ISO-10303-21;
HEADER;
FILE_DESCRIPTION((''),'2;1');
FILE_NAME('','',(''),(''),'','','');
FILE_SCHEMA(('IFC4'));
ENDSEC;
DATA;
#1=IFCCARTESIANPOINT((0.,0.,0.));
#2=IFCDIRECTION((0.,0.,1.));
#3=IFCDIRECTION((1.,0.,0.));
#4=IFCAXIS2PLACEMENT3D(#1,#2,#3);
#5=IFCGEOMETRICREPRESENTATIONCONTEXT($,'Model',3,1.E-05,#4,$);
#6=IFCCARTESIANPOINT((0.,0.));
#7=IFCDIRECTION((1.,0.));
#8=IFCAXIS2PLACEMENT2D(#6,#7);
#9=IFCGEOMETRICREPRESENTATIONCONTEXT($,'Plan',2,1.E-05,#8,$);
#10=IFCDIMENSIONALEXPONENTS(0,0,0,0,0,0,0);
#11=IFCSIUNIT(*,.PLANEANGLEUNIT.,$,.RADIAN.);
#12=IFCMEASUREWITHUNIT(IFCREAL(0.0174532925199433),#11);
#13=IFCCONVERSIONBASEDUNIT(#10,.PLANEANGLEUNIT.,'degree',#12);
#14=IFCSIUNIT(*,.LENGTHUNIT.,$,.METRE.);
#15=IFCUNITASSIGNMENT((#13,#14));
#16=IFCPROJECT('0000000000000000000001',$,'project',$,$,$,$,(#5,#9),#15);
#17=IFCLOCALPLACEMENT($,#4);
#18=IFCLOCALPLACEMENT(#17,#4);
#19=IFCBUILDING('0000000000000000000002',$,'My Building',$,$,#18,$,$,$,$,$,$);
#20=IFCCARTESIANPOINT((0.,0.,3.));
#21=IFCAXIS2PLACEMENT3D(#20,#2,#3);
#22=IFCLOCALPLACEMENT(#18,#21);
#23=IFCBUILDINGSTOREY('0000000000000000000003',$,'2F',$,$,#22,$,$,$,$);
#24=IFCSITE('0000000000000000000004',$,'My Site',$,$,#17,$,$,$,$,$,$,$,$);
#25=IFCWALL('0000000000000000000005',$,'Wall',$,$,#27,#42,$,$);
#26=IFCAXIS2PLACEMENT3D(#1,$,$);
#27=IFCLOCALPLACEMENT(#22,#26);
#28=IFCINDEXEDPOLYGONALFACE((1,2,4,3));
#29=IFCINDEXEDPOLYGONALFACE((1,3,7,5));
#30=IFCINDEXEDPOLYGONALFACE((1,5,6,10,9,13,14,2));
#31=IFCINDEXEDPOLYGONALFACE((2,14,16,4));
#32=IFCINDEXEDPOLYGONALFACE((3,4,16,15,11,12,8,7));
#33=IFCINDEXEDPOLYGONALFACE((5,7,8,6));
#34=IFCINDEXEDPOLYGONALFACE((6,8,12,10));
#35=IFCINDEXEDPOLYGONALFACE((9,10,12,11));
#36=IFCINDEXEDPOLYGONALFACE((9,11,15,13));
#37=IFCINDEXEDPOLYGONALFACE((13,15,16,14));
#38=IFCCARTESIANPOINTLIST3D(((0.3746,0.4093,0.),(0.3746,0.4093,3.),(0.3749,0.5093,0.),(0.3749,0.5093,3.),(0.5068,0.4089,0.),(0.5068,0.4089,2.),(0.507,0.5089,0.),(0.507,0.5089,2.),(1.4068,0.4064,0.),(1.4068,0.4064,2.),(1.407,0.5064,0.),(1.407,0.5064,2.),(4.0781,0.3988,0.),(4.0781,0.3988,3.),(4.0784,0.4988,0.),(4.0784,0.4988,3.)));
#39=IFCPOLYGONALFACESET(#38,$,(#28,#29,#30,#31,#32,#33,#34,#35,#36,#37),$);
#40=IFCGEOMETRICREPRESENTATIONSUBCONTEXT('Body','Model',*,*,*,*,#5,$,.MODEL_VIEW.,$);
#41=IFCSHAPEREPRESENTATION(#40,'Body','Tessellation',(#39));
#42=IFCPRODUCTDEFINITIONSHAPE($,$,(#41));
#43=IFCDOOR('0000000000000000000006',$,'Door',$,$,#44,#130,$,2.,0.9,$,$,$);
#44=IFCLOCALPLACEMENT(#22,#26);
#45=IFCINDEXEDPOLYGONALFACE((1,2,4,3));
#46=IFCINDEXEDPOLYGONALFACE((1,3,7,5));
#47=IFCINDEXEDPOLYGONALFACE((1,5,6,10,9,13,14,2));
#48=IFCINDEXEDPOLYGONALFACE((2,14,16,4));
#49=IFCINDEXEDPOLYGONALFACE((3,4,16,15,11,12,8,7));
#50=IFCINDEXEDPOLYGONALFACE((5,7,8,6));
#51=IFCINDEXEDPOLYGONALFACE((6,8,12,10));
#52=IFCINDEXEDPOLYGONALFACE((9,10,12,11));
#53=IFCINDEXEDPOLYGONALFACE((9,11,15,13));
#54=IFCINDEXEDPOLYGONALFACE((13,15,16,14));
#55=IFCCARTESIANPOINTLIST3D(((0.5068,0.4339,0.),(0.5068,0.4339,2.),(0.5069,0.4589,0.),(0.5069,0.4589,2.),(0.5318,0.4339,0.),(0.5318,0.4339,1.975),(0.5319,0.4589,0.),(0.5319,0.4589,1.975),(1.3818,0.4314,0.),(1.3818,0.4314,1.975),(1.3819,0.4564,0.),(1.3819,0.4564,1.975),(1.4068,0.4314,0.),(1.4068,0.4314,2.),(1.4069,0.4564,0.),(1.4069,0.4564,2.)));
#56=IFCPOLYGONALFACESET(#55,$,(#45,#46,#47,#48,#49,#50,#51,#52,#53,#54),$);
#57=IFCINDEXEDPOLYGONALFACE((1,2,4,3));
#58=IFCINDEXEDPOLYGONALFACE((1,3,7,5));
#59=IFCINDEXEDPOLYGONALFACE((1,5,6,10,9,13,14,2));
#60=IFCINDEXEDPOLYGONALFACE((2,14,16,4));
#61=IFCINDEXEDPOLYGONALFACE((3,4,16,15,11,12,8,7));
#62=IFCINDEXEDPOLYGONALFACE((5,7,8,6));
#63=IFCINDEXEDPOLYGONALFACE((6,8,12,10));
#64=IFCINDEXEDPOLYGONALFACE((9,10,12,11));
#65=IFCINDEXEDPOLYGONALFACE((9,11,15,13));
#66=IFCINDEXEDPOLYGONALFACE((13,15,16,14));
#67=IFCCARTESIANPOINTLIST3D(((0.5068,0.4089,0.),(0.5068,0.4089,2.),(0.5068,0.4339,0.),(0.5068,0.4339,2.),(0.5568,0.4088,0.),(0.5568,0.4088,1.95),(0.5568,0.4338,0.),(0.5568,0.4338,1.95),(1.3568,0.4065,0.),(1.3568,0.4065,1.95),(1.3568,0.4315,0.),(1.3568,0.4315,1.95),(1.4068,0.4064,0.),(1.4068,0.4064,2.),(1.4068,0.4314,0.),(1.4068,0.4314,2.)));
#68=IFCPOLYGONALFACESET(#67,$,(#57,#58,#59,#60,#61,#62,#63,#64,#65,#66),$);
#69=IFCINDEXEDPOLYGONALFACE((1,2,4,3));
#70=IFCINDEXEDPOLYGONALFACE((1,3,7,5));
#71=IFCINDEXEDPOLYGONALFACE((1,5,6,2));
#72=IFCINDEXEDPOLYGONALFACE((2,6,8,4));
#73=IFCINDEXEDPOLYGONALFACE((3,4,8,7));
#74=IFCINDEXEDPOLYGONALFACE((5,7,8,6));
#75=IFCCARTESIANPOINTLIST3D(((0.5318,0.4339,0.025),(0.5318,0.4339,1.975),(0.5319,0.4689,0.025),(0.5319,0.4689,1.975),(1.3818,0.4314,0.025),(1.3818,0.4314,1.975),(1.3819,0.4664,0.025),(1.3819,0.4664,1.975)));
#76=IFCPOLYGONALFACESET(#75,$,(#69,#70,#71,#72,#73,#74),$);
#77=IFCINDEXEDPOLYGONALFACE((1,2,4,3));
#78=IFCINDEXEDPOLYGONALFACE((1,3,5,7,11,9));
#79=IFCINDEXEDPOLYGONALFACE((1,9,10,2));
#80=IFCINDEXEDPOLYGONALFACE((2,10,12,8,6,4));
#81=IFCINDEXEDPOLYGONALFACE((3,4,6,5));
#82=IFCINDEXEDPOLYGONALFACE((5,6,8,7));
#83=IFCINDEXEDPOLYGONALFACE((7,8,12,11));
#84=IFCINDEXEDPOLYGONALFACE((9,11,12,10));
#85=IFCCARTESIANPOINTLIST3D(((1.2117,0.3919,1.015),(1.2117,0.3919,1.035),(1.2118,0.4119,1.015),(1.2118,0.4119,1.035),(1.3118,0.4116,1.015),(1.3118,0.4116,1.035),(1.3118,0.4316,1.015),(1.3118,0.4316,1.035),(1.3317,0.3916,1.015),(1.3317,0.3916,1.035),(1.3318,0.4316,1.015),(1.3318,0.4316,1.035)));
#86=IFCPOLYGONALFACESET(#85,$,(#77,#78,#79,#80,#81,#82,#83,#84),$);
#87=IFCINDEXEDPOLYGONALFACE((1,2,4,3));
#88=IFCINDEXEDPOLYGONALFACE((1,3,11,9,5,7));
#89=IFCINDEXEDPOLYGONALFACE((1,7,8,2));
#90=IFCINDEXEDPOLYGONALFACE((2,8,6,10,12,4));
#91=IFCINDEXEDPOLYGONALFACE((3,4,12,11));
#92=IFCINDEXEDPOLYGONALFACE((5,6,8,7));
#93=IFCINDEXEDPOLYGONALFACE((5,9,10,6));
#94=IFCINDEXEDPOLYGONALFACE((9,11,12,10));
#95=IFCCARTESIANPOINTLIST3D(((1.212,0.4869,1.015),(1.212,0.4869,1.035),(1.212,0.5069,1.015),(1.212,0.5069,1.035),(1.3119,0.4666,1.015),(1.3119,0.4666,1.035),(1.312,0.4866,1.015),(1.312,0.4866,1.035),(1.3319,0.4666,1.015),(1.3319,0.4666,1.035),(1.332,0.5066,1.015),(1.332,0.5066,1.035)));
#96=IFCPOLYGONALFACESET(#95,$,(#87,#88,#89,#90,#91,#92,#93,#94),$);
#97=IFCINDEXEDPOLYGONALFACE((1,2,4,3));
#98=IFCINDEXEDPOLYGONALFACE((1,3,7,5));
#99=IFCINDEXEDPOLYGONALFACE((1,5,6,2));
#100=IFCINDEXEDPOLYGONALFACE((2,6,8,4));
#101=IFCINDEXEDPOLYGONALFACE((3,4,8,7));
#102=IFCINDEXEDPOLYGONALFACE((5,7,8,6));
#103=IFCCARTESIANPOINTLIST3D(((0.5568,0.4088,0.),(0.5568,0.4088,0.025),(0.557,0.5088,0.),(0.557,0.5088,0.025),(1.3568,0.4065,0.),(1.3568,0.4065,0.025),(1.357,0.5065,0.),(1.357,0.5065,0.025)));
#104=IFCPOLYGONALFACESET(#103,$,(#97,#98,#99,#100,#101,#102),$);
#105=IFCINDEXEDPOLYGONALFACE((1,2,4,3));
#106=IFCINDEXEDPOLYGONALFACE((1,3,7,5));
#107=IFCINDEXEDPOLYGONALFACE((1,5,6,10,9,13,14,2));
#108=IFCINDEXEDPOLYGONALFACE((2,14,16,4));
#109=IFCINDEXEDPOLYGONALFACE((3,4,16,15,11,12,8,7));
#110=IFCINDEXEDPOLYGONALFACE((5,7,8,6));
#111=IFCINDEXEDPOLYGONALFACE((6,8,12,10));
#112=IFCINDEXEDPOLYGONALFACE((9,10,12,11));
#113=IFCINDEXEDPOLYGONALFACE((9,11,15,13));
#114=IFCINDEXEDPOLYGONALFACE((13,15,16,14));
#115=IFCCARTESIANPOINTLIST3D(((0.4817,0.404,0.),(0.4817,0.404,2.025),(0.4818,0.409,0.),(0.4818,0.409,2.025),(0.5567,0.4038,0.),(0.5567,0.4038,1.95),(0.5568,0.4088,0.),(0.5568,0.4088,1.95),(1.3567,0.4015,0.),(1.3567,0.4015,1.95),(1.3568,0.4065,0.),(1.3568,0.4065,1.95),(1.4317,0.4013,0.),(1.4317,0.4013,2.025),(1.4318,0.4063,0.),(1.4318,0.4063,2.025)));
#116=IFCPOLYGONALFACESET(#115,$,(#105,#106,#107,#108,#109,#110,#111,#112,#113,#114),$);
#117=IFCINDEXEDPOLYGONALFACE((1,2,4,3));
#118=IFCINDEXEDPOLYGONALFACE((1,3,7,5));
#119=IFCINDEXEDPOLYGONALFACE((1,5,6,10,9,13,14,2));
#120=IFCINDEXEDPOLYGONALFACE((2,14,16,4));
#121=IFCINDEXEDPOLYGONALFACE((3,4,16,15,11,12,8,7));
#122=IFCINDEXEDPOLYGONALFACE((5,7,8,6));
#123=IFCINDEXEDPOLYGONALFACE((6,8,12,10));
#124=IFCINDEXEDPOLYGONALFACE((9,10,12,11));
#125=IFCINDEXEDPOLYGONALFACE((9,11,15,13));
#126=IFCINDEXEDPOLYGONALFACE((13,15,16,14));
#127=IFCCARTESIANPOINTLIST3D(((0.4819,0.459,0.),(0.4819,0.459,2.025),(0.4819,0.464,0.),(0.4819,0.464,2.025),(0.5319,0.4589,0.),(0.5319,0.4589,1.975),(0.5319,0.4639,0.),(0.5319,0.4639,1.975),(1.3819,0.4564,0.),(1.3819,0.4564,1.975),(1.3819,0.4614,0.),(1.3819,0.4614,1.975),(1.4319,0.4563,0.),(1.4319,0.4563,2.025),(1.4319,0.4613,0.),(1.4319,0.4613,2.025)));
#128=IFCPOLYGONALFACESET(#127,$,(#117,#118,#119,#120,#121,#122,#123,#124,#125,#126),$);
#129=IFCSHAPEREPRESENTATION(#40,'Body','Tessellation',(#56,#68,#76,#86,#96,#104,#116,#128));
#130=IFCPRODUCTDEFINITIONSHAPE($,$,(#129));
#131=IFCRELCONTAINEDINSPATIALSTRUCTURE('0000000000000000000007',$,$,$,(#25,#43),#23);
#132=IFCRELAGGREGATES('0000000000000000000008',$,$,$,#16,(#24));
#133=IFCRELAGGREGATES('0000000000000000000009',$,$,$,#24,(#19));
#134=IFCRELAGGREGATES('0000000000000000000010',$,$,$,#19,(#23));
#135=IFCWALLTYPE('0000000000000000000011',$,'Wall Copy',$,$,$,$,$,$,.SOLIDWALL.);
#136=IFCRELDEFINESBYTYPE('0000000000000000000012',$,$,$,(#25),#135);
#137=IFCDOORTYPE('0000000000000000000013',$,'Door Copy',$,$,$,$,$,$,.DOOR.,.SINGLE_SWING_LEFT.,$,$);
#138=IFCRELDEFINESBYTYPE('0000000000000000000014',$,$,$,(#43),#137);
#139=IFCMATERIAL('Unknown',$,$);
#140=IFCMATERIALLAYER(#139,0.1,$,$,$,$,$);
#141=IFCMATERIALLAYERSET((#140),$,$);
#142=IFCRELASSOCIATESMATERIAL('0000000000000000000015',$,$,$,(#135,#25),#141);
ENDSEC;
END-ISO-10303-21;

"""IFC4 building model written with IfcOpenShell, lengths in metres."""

from ifc_helpers import new_model, entity, si_unit, converted_unit, frame, origin_with_axes, origin_2d_with_axis, place, context, subcontext, project, spatial, line, indexed_curve, outline, extrude, shape, source, transform, mapped, material, layer, layer_set, layer_usage, type_object, type_shapes, element, fill, save


model = new_model("IFC4")

# Units and contexts
model_context = context("Model", 3, precision=1e-05, world=origin_with_axes())
plan_context = context("Plan", 2, precision=1e-05, world=origin_2d_with_axis())
body_context_1 = subcontext(model_context, "Body", "Model", "MODEL_VIEW")
body_context_2 = subcontext(plan_context, "Body", "Plan", "PLAN_VIEW")
ifc_project = project(units=[converted_unit("PLANEANGLEUNIT", "degree", entity("IfcReal", 0.0174532925199433), si_unit("PLANEANGLEUNIT", "RADIAN"), dimensions=[0, 0, 0, 0, 0, 0, 0]), si_unit("LENGTHUNIT", "METRE")], contexts=[model_context, plan_context])

# Site, building, storey
site_placement = place(None, origin_with_axes())
site = spatial("IfcSite", under=ifc_project, at=site_placement, Name="My Site")
building_placement = place(site_placement, origin_with_axes())
building = spatial("IfcBuilding", under=site, at=building_placement, Name="My Building")
storey_placement = place(building_placement, frame((0.0, 0.0, 3.0), z_axis=(0.0, 0.0, 1.0), x_axis=(1.0, 0.0, 0.0)))
storey = spatial("IfcBuildingStorey", under=building, at=storey_placement, Name="2F")

# Shared definitions
ifc_material = material(Name="Unknown")

# Shared definitions
ifc_layer_1 = layer(ifc_material, 0.1)
ifc_layer_set_1 = layer_set([ifc_layer_1])
wall_type = type_object("IfcWallType", Name="Wall Copy", PredefinedType="SOLIDWALL", material=ifc_layer_set_1)
shared_shape_1 = source(origin_with_axes(), body_context_1, "Body", "SweptSolid", [
    extrude(outline(indexed_curve([(0.0, 0.0), (0.9, 0.0), (0.9, 2.0), (0.0, 2.0)], segments=[line(1, 2, 3, 4, 1)])), frame((0.0, -0.6, 0.0), z_axis=(0.0, -1.0, 0.0), x_axis=(1.0, 0.0, 0.0)), (0.0, 0.0, -1.0), 1.2),
])
door_type = type_object("IfcDoorType", Name="Door Copy", OperationType="SINGLE_SWING_LEFT", PredefinedType="DOOR")
shared_shape_2 = source(origin_with_axes(), body_context_1, "Body", "SweptSolid", [
    extrude(outline(indexed_curve([(0.0, 0.0), (0.0, 2.0), (0.9, 2.0), (0.9, 0.0), (0.875, 0.0), (0.875, 1.975), (0.025, 1.975), (0.025, 0.0)], segments=[line(1, 2, 3, 4, 5, 6, 7, 8, 1)])), frame((0.0, 0.025, 0.0), z_axis=(0.0, -1.0, 0.0), x_axis=(1.0, 0.0, 0.0)), (0.0, 0.0, -1.0), 0.025),
    extrude(outline(indexed_curve([(0.0, 0.0), (0.0, 2.0), (0.9, 2.0), (0.9, 0.0), (0.85, 0.0), (0.85, 1.95), (0.05, 1.95), (0.05, 0.0)], segments=[line(1, 2, 3, 4, 5, 6, 7, 8, 1)])), frame((0.0, 0.0, 0.0), z_axis=(0.0, -1.0, 0.0), x_axis=(1.0, 0.0, 0.0)), (0.0, 0.0, -1.0), 0.025),
    extrude(outline(indexed_curve([(0.0, 0.0), (0.85, 0.0), (0.85, 0.035), (0.0, 0.035)], segments=[line(1, 2, 3, 4, 1)])), frame((0.025, 0.025, 0.025), z_axis=(0.0, 0.0, 1.0), x_axis=(1.0, 0.0, 0.0)), (0.0, 0.0, 1.0), 1.95),
    extrude(outline(indexed_curve([(0.0, 0.0), (0.0, -0.04), (-0.12, -0.04), (-0.12, -0.02), (-0.02, -0.02), (-0.02, 0.0)], segments=[line(1, 2, 3, 4, 5, 6, 1)])), frame((0.825, 0.025, 1.015), z_axis=(0.0, 0.0, 1.0), x_axis=(1.0, 0.0, 0.0)), (0.0, 0.0, 1.0), 0.02),
    extrude(outline(indexed_curve([(0.0, 0.0), (0.0, 0.04), (-0.12, 0.04), (-0.12, 0.02), (-0.02, 0.02), (-0.02, 0.0)], segments=[line(1, 2, 3, 4, 5, 6, 1)])), frame((0.825, 0.06, 1.015), z_axis=(0.0, 0.0, 1.0), x_axis=(1.0, 0.0, 0.0)), (0.0, 0.0, 1.0), 0.02),
    extrude(outline(indexed_curve([(0.0, 0.0), (0.8, 0.0), (0.8, 0.1), (0.0, 0.1)], segments=[line(1, 2, 3, 4, 1)])), frame((0.05, 0.0, 0.0), z_axis=(0.0, 0.0, 1.0), x_axis=(1.0, 0.0, 0.0)), (0.0, 0.0, 1.0), 0.025),
    extrude(outline(indexed_curve([(0.0, 0.0), (0.0, 2.025), (0.95, 2.025), (0.95, 0.0), (0.875, 0.0), (0.875, 1.95), (0.075, 1.95), (0.075, 0.0)], segments=[line(1, 2, 3, 4, 5, 6, 7, 8, 1)])), frame((-0.025, -0.005, 0.0), z_axis=(0.0, -1.0, 0.0), x_axis=(1.0, 0.0, 0.0)), (0.0, 0.0, -1.0), 0.005),
    extrude(outline(indexed_curve([(0.0, 0.0), (0.0, 2.025), (0.95, 2.025), (0.95, 0.0), (0.9, 0.0), (0.9, 1.975), (0.05, 1.975), (0.05, 0.0)], segments=[line(1, 2, 3, 4, 5, 6, 7, 8, 1)])), frame((-0.025, 0.05, 0.0), z_axis=(0.0, -1.0, 0.0), x_axis=(1.0, 0.0, 0.0)), (0.0, 0.0, -1.0), 0.005),
])
shared_shape_3 = source(origin_with_axes(), body_context_2, "Body", "Curve2D", [
    entity("IfcIndexedPolyCurve", entity("IfcCartesianPointList2D", [[0.0, 0.0], [0.0, 0.05], [0.025, 0.05], [0.025, 0.025], [0.05, 0.025], [0.05, 0.0]]), [entity("IfcLineIndex", [1, 2, 3, 4, 5, 6, 1])]),
    entity("IfcIndexedPolyCurve", entity("IfcCartesianPointList2D", [[0.9, 0.0], [0.9, 0.05], [0.875, 0.05], [0.875, 0.025], [0.85, 0.025], [0.85, 0.0]]), [entity("IfcLineIndex", [1, 2, 3, 4, 5, 6, 1])]),
    entity("IfcTrimmedCurve", entity("IfcEllipse", entity("IfcAxis2Placement2D", entity("IfcCartesianPoint", [0.06, 0.05]), entity("IfcDirection", [1.0, 0.0])), 0.815, 0.85), [entity("IfcCartesianPoint", [0.875, 0.05])], [entity("IfcCartesianPoint", [0.06, 0.9])], True, "CARTESIAN"),
    entity("IfcIndexedPolyCurve", entity("IfcCartesianPointList2D", [[0.025, 0.05], [0.06, 0.05], [0.06, 0.9], [0.025, 0.9]]), [entity("IfcLineIndex", [1, 2, 3, 4, 1])]),
])
type_shapes(door_type, [shared_shape_2, shared_shape_3])

# Wall, opening, door
ifc_layer_usage_1 = layer_usage(ifc_layer_set_1, "AXIS2", "POSITIVE", 0.0)
wall_1_placement = place(storey_placement, frame((0.3746, 0.4093, 0.0), z_axis=(0.0, 0.0, 1.0), x_axis=(0.999996, -0.002846, 0.0)))
wall_1 = element("IfcWall", 1, at=wall_1_placement, inside=storey, type_object=wall_type, material=ifc_layer_usage_1, Name="Wall", context=body_context_1, shape_type="SweptSolid", body=[
    extrude(outline(indexed_curve([(0.0, 0.0), (0.0, 0.1), (3.7035, 0.1), (3.7035, 0.0)], segments=[line(1, 2, 3, 4, 1)])), origin_with_axes(), (0.0, 0.0, 1.0), 3.0),
])
opening_1_placement = place(wall_1_placement, frame((0.1321, 0.0, 0.0), z_axis=(0.0, 0.0, 1.0), x_axis=(1.0, 0.0, 0.0)))
opening_1 = element("IfcOpeningElement", 2, at=opening_1_placement, cuts=wall_1, PredefinedType="OPENING", context=body_context_1, shape_type="MappedRepresentation", body=[
    mapped(shared_shape_1, transform((0.0, 0.0, 0.0), x_axis=(1.0, 0.0, 0.0), y_axis=(0.0, 1.0, 0.0), z_axis=(0.0, 0.0, 1.0), scale=1.0)),
])
door_1_placement = place(opening_1_placement, frame((0.0, 0.0, 0.0), z_axis=(0.0, 0.0, 1.0), x_axis=(1.0, 0.0, 0.0)))
door_1 = element("IfcDoor", 3, at=door_1_placement, inside=storey, type_object=door_type, Name="Door", OverallHeight=2.0, OverallWidth=0.9, shapes=[
    shape(body_context_1, "Body", "MappedRepresentation", [mapped(shared_shape_2, transform((0.0, 0.0, 0.0), x_axis=(1.0, 0.0, 0.0), y_axis=(0.0, 1.0, 0.0), z_axis=(0.0, 0.0, 1.0), scale=1.0))]),
    shape(body_context_2, "Body", "MappedRepresentation", [mapped(shared_shape_3, transform((0.0, 0.0, 0.0), x_axis=(1.0, 0.0, 0.0), y_axis=(0.0, 1.0, 0.0), z_axis=(0.0, 0.0, 1.0), scale=1.0))]),
])
fill(opening_1, door_1)

save(model, "model.ifc")
